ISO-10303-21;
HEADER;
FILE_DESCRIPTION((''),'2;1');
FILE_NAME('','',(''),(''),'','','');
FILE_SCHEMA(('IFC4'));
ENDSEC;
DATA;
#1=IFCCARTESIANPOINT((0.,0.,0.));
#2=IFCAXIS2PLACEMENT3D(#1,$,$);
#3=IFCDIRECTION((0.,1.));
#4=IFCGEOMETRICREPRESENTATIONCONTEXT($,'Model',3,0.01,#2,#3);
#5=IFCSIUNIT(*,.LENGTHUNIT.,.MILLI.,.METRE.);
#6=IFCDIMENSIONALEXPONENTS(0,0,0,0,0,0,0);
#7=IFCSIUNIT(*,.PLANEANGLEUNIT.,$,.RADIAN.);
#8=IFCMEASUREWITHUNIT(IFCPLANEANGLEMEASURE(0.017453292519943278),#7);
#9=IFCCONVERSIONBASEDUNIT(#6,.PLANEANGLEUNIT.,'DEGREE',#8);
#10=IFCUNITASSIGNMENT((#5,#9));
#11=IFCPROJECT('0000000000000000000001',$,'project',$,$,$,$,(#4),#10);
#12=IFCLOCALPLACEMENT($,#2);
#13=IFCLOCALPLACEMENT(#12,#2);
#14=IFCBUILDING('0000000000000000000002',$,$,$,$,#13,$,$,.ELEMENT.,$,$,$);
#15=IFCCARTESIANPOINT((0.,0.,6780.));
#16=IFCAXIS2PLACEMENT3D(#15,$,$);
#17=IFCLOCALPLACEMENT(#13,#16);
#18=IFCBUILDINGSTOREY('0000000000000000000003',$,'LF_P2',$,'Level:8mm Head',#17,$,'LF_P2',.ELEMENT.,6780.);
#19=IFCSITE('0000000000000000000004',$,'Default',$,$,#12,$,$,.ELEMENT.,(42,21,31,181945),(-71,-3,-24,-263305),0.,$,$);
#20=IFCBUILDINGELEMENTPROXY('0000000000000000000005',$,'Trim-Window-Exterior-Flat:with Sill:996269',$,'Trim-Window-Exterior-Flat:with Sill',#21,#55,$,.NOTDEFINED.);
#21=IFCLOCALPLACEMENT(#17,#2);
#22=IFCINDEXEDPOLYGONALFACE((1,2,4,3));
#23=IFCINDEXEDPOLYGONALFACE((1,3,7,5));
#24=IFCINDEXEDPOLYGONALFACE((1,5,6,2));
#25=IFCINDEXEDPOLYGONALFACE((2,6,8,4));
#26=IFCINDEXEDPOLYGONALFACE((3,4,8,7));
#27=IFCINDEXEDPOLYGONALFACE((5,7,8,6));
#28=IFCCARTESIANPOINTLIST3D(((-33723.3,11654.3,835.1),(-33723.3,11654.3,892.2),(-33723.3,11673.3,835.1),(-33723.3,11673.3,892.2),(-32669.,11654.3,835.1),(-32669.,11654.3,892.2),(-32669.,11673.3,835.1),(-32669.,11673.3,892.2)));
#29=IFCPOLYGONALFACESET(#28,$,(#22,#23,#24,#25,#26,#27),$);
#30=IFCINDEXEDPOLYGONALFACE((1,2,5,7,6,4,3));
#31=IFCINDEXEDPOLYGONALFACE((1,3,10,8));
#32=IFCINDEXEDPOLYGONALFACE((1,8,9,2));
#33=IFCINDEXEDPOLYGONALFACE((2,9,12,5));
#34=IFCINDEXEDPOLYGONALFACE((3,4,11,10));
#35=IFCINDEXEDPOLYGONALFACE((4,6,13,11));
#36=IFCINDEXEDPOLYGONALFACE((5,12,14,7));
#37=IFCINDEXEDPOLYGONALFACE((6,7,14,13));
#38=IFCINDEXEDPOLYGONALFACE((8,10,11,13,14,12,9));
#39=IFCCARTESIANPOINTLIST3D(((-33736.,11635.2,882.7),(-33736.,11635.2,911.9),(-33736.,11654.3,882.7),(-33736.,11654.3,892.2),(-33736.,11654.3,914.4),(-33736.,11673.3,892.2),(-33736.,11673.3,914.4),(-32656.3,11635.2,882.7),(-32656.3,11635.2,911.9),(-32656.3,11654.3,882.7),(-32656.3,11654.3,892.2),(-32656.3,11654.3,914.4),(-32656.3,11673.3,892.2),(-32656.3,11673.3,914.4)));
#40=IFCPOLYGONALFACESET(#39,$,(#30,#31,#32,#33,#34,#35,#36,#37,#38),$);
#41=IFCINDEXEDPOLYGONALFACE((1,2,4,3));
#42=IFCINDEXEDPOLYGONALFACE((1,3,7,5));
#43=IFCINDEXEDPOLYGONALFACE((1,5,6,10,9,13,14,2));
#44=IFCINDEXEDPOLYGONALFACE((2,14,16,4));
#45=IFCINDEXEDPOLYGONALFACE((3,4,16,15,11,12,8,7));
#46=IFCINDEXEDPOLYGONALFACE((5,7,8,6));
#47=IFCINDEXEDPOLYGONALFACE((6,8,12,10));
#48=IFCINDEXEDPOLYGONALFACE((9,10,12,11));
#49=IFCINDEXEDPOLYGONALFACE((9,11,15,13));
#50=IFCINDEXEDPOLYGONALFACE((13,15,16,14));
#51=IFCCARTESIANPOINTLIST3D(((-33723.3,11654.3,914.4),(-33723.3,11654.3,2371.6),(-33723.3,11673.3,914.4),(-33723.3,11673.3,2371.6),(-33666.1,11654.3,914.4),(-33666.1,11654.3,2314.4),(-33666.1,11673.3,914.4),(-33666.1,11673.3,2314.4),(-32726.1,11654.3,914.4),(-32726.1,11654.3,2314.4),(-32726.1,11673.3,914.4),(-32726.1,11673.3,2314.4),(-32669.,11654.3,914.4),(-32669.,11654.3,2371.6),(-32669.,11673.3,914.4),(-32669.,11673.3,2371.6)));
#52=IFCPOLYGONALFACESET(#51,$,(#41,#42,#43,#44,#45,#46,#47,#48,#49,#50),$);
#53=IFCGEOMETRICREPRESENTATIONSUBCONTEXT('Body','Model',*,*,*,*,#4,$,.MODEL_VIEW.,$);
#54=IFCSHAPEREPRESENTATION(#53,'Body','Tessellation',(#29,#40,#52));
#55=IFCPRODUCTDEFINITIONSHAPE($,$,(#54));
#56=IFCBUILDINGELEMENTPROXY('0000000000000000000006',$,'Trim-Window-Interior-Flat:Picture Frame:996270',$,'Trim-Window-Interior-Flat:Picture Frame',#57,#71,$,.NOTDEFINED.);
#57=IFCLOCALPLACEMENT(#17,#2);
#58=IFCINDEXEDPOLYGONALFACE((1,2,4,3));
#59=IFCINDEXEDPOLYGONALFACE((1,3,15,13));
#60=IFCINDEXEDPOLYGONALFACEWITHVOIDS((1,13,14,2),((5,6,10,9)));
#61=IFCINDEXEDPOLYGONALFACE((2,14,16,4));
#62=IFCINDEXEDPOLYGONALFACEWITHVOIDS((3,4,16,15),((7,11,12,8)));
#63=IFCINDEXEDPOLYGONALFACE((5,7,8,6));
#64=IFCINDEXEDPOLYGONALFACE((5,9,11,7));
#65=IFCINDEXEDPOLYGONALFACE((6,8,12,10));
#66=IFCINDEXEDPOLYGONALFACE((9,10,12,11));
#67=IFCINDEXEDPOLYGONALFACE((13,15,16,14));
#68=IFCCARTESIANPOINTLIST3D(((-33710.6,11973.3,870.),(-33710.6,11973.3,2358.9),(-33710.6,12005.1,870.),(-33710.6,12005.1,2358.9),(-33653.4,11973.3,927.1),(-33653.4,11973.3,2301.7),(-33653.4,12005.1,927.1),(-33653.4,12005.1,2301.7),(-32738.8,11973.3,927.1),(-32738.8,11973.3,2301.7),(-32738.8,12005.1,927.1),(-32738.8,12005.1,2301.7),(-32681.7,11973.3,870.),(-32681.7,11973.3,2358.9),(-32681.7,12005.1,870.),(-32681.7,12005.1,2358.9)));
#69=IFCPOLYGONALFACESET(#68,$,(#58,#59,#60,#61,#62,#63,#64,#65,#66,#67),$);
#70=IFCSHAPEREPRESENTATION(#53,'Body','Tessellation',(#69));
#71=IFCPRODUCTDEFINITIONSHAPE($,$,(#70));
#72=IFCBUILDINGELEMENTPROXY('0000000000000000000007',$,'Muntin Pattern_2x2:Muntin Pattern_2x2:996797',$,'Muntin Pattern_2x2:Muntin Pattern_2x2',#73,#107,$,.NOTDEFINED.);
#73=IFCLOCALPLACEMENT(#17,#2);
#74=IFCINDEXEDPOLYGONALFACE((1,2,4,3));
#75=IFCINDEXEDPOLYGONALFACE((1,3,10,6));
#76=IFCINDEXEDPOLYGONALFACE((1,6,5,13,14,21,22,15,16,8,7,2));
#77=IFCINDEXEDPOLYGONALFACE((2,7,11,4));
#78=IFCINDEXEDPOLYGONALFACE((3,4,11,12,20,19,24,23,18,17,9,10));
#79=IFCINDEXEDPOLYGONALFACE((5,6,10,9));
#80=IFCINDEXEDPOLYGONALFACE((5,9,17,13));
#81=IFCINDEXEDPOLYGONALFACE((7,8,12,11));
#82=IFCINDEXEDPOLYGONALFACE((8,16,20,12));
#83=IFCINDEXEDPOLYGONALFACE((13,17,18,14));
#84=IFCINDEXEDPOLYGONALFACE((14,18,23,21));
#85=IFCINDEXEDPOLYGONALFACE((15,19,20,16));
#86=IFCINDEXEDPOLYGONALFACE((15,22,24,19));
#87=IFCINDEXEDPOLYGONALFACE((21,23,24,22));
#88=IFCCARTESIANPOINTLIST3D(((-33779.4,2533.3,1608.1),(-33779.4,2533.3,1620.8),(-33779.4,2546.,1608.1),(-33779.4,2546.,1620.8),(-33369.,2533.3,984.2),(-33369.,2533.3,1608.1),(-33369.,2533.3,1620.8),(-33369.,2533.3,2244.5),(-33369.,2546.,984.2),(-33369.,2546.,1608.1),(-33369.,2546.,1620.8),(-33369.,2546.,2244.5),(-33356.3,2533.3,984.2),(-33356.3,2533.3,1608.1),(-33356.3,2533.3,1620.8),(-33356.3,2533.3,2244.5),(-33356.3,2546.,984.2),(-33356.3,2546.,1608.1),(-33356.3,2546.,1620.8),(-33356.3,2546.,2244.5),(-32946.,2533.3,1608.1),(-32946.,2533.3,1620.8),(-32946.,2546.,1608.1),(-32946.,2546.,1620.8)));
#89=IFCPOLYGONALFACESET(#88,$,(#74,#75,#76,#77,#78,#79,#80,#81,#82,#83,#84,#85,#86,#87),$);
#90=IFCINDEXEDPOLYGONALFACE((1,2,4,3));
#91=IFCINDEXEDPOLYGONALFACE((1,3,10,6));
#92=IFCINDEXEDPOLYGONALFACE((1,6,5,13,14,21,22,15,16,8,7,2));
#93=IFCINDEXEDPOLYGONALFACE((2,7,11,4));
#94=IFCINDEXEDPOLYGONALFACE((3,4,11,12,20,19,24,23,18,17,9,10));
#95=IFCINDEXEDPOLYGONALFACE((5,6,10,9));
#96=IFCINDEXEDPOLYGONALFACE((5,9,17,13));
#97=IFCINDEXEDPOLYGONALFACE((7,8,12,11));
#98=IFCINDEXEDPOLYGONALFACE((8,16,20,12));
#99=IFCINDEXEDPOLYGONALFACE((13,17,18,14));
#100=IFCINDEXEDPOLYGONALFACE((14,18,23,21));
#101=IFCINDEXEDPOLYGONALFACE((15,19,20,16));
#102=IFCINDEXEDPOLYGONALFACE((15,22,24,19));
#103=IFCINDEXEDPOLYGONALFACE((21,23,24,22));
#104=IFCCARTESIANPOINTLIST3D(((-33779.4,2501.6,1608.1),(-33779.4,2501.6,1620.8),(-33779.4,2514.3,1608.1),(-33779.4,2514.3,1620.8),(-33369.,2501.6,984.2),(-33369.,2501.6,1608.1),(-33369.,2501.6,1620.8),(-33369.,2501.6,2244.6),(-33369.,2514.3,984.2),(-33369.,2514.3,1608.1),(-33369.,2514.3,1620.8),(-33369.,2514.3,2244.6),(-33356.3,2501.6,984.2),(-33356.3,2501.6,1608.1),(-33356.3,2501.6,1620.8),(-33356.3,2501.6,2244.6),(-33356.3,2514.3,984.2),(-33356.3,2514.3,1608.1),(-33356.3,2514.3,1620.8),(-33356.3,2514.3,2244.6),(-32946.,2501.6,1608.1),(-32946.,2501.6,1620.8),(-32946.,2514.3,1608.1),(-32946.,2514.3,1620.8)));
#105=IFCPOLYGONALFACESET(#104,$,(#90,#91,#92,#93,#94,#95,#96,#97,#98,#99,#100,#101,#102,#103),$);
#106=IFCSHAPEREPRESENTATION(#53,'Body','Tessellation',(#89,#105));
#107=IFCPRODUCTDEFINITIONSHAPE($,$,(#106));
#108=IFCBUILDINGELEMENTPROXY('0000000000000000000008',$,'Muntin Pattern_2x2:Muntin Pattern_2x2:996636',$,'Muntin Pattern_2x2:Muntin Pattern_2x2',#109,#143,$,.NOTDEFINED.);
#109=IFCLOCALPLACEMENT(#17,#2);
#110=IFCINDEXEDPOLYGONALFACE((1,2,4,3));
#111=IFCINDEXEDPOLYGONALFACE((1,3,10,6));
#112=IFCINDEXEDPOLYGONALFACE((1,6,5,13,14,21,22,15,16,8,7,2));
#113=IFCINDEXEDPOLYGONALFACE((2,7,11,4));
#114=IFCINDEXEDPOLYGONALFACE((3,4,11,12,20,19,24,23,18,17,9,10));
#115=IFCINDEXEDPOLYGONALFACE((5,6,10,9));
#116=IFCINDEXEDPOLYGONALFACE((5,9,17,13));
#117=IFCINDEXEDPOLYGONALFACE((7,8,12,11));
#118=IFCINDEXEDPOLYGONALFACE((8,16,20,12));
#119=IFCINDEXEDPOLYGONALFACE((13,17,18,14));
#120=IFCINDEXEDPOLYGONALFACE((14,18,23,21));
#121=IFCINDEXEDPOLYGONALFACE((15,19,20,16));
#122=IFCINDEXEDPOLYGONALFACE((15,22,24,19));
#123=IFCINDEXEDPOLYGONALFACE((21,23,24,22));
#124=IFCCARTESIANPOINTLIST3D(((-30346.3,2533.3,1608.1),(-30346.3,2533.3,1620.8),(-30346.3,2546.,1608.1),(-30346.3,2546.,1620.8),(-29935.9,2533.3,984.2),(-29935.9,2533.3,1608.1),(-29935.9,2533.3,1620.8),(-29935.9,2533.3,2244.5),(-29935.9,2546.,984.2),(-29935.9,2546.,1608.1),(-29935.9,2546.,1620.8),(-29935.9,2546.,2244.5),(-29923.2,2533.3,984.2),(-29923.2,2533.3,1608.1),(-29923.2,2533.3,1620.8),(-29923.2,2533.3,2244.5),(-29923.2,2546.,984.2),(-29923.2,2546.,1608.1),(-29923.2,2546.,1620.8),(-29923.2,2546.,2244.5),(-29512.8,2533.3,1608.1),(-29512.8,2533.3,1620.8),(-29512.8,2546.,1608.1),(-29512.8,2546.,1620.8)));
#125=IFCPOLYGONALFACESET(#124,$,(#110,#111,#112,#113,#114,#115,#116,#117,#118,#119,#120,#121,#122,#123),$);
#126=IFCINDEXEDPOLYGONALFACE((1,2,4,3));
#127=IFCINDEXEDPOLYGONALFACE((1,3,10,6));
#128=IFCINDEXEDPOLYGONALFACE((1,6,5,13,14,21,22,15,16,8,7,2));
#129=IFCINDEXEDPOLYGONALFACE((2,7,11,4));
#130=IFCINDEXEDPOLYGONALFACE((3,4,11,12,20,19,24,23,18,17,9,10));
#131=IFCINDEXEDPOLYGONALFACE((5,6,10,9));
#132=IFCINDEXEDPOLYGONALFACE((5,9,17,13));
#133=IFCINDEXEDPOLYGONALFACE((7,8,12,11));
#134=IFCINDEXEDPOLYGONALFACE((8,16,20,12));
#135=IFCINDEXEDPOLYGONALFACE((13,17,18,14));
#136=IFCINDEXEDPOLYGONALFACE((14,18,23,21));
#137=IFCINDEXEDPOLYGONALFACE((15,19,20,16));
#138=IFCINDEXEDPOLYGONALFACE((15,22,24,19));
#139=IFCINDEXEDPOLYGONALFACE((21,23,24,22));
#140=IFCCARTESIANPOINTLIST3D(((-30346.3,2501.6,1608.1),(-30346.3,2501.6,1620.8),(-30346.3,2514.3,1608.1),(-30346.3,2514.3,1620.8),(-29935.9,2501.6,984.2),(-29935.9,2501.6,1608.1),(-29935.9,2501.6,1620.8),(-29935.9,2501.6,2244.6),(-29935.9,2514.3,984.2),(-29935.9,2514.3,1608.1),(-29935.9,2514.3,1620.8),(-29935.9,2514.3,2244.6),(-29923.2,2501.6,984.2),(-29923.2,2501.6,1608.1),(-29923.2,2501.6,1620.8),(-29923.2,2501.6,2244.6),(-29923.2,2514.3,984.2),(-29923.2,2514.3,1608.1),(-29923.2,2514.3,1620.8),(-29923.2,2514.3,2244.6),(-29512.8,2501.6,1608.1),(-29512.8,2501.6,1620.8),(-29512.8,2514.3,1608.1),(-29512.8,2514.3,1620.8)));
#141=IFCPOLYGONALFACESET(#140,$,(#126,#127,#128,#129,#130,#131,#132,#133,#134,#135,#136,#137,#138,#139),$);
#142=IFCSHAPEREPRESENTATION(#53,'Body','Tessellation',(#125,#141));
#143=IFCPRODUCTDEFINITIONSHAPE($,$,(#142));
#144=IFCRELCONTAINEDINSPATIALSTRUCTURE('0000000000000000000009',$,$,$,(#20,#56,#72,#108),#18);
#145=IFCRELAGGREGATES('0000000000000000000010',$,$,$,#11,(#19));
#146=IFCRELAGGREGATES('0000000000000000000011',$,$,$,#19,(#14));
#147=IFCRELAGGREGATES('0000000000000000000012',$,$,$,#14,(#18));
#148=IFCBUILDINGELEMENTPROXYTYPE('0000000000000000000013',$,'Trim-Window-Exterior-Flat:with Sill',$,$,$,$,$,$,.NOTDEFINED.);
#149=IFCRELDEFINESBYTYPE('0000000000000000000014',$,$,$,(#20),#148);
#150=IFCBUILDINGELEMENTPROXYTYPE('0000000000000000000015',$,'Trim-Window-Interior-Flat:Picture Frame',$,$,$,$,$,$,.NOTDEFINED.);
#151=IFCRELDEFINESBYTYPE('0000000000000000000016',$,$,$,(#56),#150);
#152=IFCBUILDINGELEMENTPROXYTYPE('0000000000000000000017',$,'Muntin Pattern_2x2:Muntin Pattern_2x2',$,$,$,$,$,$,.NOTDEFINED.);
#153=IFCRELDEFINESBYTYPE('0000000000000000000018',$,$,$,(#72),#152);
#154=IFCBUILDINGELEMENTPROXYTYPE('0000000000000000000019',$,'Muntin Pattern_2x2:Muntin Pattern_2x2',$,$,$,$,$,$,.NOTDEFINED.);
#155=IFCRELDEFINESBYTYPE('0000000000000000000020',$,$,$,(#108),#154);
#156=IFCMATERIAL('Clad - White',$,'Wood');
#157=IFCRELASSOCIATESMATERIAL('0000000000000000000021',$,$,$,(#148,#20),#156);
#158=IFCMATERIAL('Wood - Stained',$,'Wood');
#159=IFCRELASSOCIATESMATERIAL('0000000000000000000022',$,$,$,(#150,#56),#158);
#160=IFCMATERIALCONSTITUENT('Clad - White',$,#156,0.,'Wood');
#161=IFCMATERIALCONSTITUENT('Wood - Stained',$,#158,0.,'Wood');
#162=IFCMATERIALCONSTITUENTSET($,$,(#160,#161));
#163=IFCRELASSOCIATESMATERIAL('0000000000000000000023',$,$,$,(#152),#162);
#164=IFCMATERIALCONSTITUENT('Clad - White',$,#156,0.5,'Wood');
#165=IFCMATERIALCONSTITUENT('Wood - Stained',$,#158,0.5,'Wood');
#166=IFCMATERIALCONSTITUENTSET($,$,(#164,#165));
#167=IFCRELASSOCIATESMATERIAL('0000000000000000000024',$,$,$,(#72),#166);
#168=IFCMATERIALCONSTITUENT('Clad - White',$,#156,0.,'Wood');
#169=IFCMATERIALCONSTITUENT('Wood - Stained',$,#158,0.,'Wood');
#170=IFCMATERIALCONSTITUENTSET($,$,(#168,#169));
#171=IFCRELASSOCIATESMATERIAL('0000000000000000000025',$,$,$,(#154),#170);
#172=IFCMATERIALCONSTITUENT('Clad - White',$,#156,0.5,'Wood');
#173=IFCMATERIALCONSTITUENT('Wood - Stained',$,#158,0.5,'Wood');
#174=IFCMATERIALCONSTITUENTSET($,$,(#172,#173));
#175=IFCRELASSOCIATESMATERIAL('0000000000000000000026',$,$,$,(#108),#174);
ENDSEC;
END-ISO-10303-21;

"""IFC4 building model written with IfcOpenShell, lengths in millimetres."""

from ifc_helpers import new_model, entity, si_unit, converted_unit, direction, frame, origin, place, context, subcontext, project, spatial, indexed_curve, outline, extrude, source, transform, mapped, material, constituent, constituent_set, type_object, type_shapes, element, save


model = new_model("IFC4")

# Units and contexts
model_context = context("Model", 3, precision=0.01, world=origin(), true_north=direction((0.0, 1.0)))
body_context = subcontext(model_context, "Body", "Model", "MODEL_VIEW")
ifc_project = project(units=[si_unit("LENGTHUNIT", "METRE", prefix="MILLI"), converted_unit("PLANEANGLEUNIT", "DEGREE", entity("IfcPlaneAngleMeasure", 0.017453292519943278), si_unit("PLANEANGLEUNIT", "RADIAN"), dimensions=[0, 0, 0, 0, 0, 0, 0])], contexts=[model_context])

# Site, building, storey
site_placement = place(None, origin())
site = spatial("IfcSite", under=ifc_project, at=site_placement, Name="Default", CompositionType="ELEMENT", RefLatitude=(42, 21, 31, 181945), RefLongitude=(-71, -3, -24, -263305), RefElevation=0.0)
building_placement = place(site_placement, origin())
building = spatial("IfcBuilding", under=site, at=building_placement, CompositionType="ELEMENT")
storey_placement = place(building_placement, frame((0.0, 0.0, 6780.0)))
storey = spatial("IfcBuildingStorey", under=building, at=storey_placement, Name="LF_P2", ObjectType="Level:8mm Head", LongName="LF_P2", CompositionType="ELEMENT", Elevation=6780.0)

# Building element proxies
ifc_material_1 = material(Name="Clad - White", Category="Wood")
ifc_material_2 = material(Name="Wood - Stained", Category="Wood")
building_element_proxy_type_1 = type_object("IfcBuildingElementProxyType", Name="Trim-Window-Exterior-Flat:with Sill", PredefinedType="NOTDEFINED", material=ifc_material_1)
shared_shape_1 = source(origin(), body_context, "Body", "SweptSolid", [
    extrude(outline(indexed_curve([(-527.1, -28.6), (527.1, -28.6), (527.1, 28.6), (-527.1, 28.6), (-527.1, -28.6)], self_intersect=False)), frame((0.0, -1450.8, 0.0), z_axis=(0.0, 0.0, 1.0), x_axis=(-1.0, 0.0, 0.0)), (0.0, 0.0, 1.0), 19.0),
    extrude(outline(indexed_curve([(-19.0, -16.0), (0.0, -16.0), (0.0, -6.4), (19.0, -6.4), (19.0, 15.8), (0.0, 15.8), (-19.0, 13.3), (-19.0, -16.0)], self_intersect=False)), frame((-539.8, -1415.8, 19.0), z_axis=(1.0, 0.0, 0.0), x_axis=(0.0, 0.0, -1.0)), (0.0, 0.0, 1.0), 1079.7),
    extrude(outline(indexed_curve([(-742.9, -527.1), (714.3, -527.1), (714.3, -470.0), (-685.7, -470.0), (-685.7, 470.0), (714.3, 470.0), (714.3, 527.1), (-742.9, 527.1), (-742.9, -527.1)], self_intersect=False)), frame((0.0, -685.7, 0.0), z_axis=(0.0, 0.0, 1.0), x_axis=(0.0, -1.0, 0.0)), (0.0, 0.0, 1.0), 19.0),
])
type_shapes(building_element_proxy_type_1, [shared_shape_1])
proxy_1_placement = place(storey_placement, frame((-33196.1, 11673.3, 2314.4), z_axis=(0.0, -1.0, 0.0), x_axis=(1.0, 0.0, 0.0)))
element("IfcBuildingElementProxy", 1, at=proxy_1_placement, inside=storey, type_object=building_element_proxy_type_1, material=ifc_material_1, Name="Trim-Window-Exterior-Flat:with Sill:996269", ObjectType="Trim-Window-Exterior-Flat:with Sill", PredefinedType="NOTDEFINED", context=body_context, shape_type="MappedRepresentation", body=[
    mapped(shared_shape_1, transform((0.0, 0.0, 0.0), scale=1.0)),
])
building_element_proxy_type_2 = type_object("IfcBuildingElementProxyType", Name="Trim-Window-Interior-Flat:Picture Frame", PredefinedType="NOTDEFINED", material=ifc_material_2)
shared_shape_2 = source(origin(), body_context, "Body", "SweptSolid", [
    extrude(outline(indexed_curve([(-514.4, -744.4), (514.4, -744.4), (514.4, 744.4), (-514.4, 744.4), (-514.4, -744.4)], self_intersect=False), holes=[indexed_curve([(-457.3, -687.3), (-457.3, 687.3), (457.3, 687.3), (457.3, -687.3), (-457.3, -687.3)], self_intersect=False)]), frame((0.0, -700.0, 0.0), z_axis=(0.0, 0.0, 1.0), x_axis=(-1.0, 0.0, 0.0)), (0.0, 0.0, 1.0), 31.7),
])
type_shapes(building_element_proxy_type_2, [shared_shape_2])
proxy_2_placement = place(storey_placement, frame((-33196.1, 11973.3, 2314.4), z_axis=(0.0, 1.0, 0.0), x_axis=(-1.0, 0.0, 0.0)))
element("IfcBuildingElementProxy", 2, at=proxy_2_placement, inside=storey, type_object=building_element_proxy_type_2, material=ifc_material_2, Name="Trim-Window-Interior-Flat:Picture Frame:996270", ObjectType="Trim-Window-Interior-Flat:Picture Frame", PredefinedType="NOTDEFINED", context=body_context, shape_type="MappedRepresentation", body=[
    mapped(shared_shape_2, transform((0.0, 0.0, 0.0), scale=1.0)),
])
ifc_constituent_1 = constituent(ifc_material_1, Name="Clad - White", Category="Wood", fraction=0.5)
ifc_constituent_2 = constituent(ifc_material_2, Name="Wood - Stained", Category="Wood", fraction=0.5)
ifc_constituent_set_1 = constituent_set(constituents=[ifc_constituent_1, ifc_constituent_2])
ifc_constituent_3 = constituent(ifc_material_1, Name="Clad - White", Category="Wood", fraction=0.0)
ifc_constituent_4 = constituent(ifc_material_2, Name="Wood - Stained", Category="Wood", fraction=0.0)
ifc_constituent_set_2 = constituent_set(constituents=[ifc_constituent_3, ifc_constituent_4])
building_element_proxy_type_3 = type_object("IfcBuildingElementProxyType", Name="Muntin Pattern_2x2:Muntin Pattern_2x2", PredefinedType="NOTDEFINED", material=ifc_constituent_set_2)
shared_shape_3 = source(origin(), body_context, "Body", "SweptSolid", [
    extrude(outline(indexed_curve([(6.4, -6.4), (630.1, -6.4), (630.1, 6.3), (6.4, 6.3), (6.4, 416.7), (-6.3, 416.7), (-6.3, 6.3), (-630.2, 6.3), (-630.2, -6.4), (-6.3, -6.4), (-6.3, -416.7), (6.4, -416.7), (6.4, -6.4)], self_intersect=False)), frame((0.0, -22.2, 630.1), z_axis=(0.0, 1.0, 0.0), x_axis=(0.0, 0.0, 1.0)), (0.0, 0.0, 1.0), 12.7),
    extrude(outline(indexed_curve([(6.4, -6.4), (630.2, -6.4), (630.2, 6.3), (6.4, 6.3), (6.4, 416.7), (-6.3, 416.7), (-6.3, 6.3), (-630.2, 6.3), (-630.2, -6.4), (-6.3, -6.4), (-6.3, -416.7), (6.4, -416.7), (6.4, -6.4)], self_intersect=False)), frame((0.0, 9.5, 630.2), z_axis=(0.0, 1.0, 0.0), x_axis=(0.0, 0.0, 1.0)), (0.0, 0.0, 1.0), 12.7),
])
type_shapes(building_element_proxy_type_3, [shared_shape_3])
proxy_3_placement = place(storey_placement, frame((-33362.7, 2523.8, 984.3), z_axis=(0.0, 0.0, 1.0), x_axis=(-1.0, 0.0, 0.0)))
element("IfcBuildingElementProxy", 3, at=proxy_3_placement, inside=storey, type_object=building_element_proxy_type_3, material=ifc_constituent_set_1, Name="Muntin Pattern_2x2:Muntin Pattern_2x2:996797", ObjectType="Muntin Pattern_2x2:Muntin Pattern_2x2", PredefinedType="NOTDEFINED", context=body_context, shape_type="MappedRepresentation", body=[
    mapped(shared_shape_3, transform((0.0, 0.0, 0.0), scale=1.0)),
])
ifc_constituent_5 = constituent(ifc_material_1, Name="Clad - White", Category="Wood", fraction=0.5)
ifc_constituent_6 = constituent(ifc_material_2, Name="Wood - Stained", Category="Wood", fraction=0.5)
ifc_constituent_set_3 = constituent_set(constituents=[ifc_constituent_5, ifc_constituent_6])
ifc_constituent_7 = constituent(ifc_material_1, Name="Clad - White", Category="Wood", fraction=0.0)
ifc_constituent_8 = constituent(ifc_material_2, Name="Wood - Stained", Category="Wood", fraction=0.0)
ifc_constituent_set_4 = constituent_set(constituents=[ifc_constituent_7, ifc_constituent_8])
building_element_proxy_type_4 = type_object("IfcBuildingElementProxyType", Name="Muntin Pattern_2x2:Muntin Pattern_2x2", PredefinedType="NOTDEFINED", material=ifc_constituent_set_4)
shared_shape_4 = source(origin(), body_context, "Body", "SweptSolid", [
    extrude(outline(indexed_curve([(6.4, -6.4), (630.1, -6.4), (630.1, 6.3), (6.4, 6.3), (6.4, 416.7), (-6.3, 416.7), (-6.3, 6.3), (-630.2, 6.3), (-630.2, -6.4), (-6.3, -6.4), (-6.3, -416.7), (6.4, -416.7), (6.4, -6.4)], self_intersect=False)), frame((0.0, 9.5, 630.1), z_axis=(0.0, 1.0, 0.0), x_axis=(0.0, 0.0, 1.0)), (0.0, 0.0, 1.0), 12.7),
    extrude(outline(indexed_curve([(6.4, -6.4), (630.2, -6.4), (630.2, 6.3), (6.4, 6.3), (6.4, 416.7), (-6.3, 416.7), (-6.3, 6.3), (-630.2, 6.3), (-630.2, -6.4), (-6.3, -6.4), (-6.3, -416.7), (6.4, -416.7), (6.4, -6.4)], self_intersect=False)), frame((0.0, -22.2, 630.2), z_axis=(0.0, 1.0, 0.0), x_axis=(0.0, 0.0, 1.0)), (0.0, 0.0, 1.0), 12.7),
])
type_shapes(building_element_proxy_type_4, [shared_shape_4])
proxy_4_placement = place(storey_placement, frame((-29929.5, 2523.8, 984.3)))
element("IfcBuildingElementProxy", 4, at=proxy_4_placement, inside=storey, type_object=building_element_proxy_type_4, material=ifc_constituent_set_3, Name="Muntin Pattern_2x2:Muntin Pattern_2x2:996636", ObjectType="Muntin Pattern_2x2:Muntin Pattern_2x2", PredefinedType="NOTDEFINED", context=body_context, shape_type="MappedRepresentation", body=[
    mapped(shared_shape_4, transform((0.0, 0.0, 0.0), scale=1.0)),
])

save(model, "model.ifc")
